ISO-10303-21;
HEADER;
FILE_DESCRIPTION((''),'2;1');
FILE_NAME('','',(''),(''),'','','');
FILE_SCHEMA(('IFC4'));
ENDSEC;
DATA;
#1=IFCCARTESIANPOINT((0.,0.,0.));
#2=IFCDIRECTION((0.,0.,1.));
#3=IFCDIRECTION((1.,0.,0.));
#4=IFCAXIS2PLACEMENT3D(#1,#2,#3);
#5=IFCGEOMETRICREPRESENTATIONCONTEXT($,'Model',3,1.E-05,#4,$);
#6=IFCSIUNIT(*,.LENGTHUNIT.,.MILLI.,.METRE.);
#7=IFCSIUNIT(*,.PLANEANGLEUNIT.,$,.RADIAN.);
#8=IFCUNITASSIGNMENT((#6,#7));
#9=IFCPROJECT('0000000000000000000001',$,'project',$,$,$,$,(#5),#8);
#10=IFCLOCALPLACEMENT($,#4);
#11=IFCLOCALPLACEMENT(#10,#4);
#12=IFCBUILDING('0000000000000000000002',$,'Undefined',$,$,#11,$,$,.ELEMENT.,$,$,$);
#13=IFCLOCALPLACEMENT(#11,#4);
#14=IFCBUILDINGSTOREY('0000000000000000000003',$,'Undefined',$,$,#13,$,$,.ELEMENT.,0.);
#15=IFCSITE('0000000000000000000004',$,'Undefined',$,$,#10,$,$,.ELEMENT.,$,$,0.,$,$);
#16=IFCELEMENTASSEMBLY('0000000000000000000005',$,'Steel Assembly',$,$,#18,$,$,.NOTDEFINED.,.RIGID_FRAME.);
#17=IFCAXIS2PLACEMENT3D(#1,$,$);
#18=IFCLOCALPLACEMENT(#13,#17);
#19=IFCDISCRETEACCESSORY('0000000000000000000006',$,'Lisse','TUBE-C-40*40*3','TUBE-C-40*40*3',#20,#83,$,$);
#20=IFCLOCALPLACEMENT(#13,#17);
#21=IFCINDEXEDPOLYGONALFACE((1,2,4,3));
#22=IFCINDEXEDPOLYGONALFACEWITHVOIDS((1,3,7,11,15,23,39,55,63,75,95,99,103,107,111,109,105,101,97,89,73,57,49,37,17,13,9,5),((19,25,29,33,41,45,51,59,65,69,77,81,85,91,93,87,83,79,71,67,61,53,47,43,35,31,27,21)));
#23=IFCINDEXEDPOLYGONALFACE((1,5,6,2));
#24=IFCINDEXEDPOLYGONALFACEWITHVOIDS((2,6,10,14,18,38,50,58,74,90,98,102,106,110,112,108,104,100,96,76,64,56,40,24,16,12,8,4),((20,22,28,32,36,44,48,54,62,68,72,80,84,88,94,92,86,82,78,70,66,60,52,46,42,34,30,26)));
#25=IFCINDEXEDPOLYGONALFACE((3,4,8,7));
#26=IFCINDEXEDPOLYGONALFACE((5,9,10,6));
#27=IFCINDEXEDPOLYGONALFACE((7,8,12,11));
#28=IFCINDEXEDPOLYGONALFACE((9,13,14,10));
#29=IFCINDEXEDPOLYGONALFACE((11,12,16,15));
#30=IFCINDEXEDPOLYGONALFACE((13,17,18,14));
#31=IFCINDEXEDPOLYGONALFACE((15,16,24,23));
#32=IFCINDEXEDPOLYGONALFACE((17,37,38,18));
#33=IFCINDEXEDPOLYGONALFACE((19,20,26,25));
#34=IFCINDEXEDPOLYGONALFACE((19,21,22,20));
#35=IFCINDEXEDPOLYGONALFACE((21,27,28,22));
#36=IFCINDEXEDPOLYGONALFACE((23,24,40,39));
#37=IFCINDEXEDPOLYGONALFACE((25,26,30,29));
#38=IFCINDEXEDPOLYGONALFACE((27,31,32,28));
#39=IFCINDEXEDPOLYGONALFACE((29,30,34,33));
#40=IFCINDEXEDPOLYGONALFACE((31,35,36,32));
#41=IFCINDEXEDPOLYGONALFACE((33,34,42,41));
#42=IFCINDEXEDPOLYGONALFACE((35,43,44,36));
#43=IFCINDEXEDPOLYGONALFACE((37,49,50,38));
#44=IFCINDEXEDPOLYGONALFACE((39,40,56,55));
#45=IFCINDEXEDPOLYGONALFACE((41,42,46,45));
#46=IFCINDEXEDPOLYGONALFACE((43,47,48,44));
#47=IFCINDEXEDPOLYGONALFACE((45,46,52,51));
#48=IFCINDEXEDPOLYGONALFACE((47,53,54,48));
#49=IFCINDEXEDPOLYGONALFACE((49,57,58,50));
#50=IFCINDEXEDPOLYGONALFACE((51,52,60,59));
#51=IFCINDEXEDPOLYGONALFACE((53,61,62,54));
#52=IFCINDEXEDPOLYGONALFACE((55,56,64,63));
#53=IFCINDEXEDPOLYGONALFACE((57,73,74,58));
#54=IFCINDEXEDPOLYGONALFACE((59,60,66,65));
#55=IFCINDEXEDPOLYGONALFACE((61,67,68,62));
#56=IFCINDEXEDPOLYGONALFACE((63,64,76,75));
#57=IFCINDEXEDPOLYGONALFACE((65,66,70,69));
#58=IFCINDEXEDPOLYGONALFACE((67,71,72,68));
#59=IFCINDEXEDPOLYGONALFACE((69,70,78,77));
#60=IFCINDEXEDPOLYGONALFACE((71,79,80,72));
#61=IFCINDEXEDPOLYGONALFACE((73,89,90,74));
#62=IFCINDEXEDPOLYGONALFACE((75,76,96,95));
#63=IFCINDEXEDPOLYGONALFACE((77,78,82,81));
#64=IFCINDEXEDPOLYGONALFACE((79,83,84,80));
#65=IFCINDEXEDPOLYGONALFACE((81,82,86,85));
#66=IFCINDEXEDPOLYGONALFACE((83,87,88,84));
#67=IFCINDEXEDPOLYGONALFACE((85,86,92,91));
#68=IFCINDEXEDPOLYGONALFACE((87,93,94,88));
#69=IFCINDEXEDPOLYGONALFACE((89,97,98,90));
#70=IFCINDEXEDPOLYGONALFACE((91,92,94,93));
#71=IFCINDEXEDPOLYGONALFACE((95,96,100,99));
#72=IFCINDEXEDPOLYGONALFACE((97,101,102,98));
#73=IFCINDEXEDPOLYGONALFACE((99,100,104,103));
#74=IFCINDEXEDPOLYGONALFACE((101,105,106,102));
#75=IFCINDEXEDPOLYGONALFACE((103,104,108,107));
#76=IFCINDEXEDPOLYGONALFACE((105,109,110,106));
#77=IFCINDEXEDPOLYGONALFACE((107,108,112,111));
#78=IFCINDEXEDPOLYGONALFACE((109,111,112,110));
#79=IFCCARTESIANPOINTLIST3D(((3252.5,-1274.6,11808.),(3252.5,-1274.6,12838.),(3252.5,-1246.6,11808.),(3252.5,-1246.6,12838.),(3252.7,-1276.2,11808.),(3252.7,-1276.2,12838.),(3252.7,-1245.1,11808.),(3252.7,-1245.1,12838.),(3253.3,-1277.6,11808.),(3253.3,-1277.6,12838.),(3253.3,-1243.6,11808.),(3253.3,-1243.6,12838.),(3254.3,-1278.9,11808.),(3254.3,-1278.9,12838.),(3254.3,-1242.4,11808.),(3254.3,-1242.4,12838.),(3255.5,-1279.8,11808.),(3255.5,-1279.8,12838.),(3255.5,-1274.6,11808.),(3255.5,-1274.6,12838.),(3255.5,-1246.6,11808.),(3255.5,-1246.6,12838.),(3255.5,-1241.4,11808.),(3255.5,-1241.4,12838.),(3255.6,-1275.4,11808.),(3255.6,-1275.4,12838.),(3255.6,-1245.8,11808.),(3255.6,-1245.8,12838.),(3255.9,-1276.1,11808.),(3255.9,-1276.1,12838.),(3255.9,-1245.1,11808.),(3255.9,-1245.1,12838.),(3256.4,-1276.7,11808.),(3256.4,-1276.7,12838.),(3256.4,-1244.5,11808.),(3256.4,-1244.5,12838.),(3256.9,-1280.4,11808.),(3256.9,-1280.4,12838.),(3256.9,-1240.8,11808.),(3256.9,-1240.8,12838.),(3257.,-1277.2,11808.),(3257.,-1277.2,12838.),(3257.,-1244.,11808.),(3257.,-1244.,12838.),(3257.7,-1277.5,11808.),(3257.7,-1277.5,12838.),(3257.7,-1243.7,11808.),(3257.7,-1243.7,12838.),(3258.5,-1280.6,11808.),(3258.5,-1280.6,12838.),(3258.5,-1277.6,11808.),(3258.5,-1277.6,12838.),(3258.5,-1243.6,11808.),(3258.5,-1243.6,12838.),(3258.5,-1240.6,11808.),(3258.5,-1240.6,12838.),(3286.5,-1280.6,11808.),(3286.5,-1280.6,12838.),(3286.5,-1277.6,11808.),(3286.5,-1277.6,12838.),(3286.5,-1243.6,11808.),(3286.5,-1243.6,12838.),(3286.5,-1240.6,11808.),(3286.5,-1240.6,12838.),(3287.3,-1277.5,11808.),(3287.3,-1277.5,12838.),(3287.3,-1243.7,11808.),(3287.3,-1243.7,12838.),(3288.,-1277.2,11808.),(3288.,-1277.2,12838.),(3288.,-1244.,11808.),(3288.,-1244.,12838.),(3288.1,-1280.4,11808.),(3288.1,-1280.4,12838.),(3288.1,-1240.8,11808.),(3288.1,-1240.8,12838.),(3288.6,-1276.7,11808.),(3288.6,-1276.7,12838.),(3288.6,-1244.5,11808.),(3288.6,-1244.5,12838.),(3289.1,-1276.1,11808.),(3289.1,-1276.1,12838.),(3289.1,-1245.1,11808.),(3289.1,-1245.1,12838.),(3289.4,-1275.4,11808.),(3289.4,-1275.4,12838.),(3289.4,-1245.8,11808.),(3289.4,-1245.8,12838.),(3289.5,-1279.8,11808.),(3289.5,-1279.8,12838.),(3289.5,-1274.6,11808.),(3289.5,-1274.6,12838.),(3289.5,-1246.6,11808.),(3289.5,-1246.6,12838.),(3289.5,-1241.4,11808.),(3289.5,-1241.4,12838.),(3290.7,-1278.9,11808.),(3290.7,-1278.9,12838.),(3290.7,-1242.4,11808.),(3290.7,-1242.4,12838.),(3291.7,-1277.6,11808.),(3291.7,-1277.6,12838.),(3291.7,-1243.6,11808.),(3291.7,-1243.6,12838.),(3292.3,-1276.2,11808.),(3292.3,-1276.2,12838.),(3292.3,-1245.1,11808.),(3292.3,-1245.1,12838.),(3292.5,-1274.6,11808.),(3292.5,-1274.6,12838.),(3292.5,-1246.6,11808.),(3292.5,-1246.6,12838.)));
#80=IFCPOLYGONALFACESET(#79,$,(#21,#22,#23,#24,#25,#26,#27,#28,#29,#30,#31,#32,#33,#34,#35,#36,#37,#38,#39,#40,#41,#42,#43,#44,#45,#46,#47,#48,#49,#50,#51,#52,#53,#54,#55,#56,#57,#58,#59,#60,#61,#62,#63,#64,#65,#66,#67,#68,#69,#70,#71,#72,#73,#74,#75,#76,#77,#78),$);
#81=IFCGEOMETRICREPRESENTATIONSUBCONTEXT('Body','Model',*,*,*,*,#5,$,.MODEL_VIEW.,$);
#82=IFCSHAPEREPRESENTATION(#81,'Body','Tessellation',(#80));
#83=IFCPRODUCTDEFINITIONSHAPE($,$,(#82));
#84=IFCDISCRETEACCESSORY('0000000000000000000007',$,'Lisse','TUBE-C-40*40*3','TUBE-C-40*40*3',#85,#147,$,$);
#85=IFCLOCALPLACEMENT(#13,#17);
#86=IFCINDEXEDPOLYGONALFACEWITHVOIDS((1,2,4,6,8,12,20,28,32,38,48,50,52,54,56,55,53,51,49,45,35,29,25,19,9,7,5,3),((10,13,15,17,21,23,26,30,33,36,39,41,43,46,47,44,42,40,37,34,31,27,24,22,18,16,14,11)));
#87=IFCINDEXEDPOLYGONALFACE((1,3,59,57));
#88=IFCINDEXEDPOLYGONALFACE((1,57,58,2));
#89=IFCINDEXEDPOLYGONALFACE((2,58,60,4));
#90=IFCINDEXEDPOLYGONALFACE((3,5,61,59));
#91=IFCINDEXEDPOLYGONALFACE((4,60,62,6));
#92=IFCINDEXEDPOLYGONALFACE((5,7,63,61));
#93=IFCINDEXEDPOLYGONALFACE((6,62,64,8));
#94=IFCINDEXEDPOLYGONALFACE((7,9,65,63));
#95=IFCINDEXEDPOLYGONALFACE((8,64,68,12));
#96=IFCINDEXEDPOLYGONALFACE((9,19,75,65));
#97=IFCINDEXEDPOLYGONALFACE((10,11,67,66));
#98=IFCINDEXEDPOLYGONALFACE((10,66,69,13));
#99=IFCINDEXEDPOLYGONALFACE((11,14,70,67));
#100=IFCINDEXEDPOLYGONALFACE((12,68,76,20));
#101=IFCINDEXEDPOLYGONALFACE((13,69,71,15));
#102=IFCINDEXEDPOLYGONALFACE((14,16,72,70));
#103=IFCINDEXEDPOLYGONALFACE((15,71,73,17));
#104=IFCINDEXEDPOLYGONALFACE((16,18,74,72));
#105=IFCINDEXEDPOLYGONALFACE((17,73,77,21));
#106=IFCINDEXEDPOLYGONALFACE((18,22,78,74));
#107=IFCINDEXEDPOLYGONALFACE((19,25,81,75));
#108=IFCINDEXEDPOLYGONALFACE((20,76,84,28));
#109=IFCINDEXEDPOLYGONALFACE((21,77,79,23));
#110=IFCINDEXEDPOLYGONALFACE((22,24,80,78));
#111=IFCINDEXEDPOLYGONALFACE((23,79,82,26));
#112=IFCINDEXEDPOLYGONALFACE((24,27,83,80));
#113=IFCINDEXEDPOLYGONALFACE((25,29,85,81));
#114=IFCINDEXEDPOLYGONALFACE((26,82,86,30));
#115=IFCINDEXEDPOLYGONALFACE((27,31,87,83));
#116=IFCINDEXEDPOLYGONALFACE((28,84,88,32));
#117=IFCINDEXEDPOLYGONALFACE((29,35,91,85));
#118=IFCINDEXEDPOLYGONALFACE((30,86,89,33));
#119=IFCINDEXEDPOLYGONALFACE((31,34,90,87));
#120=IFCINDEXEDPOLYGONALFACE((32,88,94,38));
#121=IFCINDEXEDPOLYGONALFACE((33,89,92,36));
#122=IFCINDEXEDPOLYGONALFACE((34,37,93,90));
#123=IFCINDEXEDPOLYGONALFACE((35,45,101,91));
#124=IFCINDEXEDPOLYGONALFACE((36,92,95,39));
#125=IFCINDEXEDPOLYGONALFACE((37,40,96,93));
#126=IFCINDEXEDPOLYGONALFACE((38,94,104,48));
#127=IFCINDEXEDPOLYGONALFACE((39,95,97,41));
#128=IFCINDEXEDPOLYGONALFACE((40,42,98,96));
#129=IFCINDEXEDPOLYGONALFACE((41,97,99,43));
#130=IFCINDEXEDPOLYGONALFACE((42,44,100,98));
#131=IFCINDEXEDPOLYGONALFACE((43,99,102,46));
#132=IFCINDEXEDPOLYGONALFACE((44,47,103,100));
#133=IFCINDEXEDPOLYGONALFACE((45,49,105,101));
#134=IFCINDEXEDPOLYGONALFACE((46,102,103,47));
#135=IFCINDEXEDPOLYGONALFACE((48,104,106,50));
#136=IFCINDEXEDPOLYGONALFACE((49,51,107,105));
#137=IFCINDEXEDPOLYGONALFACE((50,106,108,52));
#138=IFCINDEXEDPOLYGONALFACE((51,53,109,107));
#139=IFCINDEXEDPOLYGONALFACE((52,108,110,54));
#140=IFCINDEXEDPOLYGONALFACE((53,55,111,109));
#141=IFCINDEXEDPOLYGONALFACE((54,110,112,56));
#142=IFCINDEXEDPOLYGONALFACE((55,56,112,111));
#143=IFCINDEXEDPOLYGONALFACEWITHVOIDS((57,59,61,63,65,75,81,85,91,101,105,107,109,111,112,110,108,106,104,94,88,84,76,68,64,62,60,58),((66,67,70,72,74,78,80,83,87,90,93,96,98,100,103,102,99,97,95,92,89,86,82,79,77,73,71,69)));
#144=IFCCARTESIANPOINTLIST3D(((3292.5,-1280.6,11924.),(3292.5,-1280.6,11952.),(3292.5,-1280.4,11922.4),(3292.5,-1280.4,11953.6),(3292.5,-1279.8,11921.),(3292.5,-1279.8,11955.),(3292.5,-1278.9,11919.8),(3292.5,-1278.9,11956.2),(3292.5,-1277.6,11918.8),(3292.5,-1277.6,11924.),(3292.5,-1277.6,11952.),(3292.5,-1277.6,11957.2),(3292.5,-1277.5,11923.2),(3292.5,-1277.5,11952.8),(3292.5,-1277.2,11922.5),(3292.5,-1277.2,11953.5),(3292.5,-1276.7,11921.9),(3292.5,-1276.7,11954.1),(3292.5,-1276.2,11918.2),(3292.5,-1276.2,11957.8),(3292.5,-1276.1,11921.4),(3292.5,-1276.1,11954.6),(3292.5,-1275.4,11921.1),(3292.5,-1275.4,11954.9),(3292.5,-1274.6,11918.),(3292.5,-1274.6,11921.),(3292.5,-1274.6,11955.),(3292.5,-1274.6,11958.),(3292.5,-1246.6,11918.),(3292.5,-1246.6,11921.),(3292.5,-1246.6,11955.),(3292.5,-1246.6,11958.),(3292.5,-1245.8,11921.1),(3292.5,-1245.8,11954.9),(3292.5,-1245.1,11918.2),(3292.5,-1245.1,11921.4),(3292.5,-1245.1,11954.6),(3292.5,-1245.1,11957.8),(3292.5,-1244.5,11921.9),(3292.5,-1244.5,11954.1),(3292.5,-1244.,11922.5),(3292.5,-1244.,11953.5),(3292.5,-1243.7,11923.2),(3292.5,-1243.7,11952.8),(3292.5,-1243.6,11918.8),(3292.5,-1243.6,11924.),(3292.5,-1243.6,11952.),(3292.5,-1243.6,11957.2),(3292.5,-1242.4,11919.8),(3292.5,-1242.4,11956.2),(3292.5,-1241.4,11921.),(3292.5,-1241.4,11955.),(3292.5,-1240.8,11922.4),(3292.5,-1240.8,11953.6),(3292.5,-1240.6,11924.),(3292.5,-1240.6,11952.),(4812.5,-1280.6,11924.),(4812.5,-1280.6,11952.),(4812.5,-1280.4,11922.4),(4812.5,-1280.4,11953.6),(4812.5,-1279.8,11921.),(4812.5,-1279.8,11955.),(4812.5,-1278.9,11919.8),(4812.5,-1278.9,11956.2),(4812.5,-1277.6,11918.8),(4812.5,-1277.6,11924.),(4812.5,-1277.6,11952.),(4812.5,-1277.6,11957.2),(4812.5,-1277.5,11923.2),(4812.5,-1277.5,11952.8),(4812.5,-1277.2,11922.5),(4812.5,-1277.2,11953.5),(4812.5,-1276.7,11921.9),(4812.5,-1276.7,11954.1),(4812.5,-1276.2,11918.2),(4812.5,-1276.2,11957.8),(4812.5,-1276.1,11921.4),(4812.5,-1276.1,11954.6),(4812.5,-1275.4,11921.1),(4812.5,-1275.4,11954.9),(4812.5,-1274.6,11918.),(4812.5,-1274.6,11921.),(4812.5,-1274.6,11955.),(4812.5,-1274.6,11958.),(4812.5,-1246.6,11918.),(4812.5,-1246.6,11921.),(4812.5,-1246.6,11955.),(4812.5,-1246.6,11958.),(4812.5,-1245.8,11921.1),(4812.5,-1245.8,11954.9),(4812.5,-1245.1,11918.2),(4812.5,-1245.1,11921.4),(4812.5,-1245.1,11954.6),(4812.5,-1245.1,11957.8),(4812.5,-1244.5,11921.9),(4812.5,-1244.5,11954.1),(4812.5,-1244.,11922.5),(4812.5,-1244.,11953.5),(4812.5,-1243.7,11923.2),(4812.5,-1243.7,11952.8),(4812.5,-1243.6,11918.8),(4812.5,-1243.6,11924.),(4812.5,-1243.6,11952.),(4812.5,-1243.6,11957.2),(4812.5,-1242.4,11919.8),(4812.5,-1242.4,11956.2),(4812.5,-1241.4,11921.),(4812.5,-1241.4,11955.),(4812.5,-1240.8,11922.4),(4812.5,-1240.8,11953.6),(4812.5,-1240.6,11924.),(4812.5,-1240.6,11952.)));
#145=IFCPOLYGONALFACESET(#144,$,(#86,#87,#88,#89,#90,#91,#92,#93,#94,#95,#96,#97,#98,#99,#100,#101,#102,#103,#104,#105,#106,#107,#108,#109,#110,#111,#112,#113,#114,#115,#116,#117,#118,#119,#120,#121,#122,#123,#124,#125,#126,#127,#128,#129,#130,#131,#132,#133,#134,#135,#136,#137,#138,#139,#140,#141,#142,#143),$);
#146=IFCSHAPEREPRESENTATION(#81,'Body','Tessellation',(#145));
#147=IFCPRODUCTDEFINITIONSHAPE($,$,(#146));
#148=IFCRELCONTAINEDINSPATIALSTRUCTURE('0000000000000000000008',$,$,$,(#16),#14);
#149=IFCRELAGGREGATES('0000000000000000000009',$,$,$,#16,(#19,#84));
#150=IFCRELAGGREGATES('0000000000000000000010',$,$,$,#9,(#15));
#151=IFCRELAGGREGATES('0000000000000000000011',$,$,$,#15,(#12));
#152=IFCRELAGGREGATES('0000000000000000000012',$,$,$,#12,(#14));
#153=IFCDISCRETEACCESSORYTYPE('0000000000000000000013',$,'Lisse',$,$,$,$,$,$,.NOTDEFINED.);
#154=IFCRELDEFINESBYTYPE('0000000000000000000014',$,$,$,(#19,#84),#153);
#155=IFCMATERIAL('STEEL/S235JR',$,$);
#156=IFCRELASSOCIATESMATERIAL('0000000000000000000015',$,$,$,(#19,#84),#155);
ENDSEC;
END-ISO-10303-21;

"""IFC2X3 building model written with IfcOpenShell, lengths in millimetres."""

from ifc_helpers import new_model, si_unit, frame, origin_with_axes, origin_2d_with_axis, place, context, subcontext, project, spatial, hollow_rectangle, extrude, material, type_object, element, aggregate, save


model = new_model("IFC2X3")

# Units and contexts
model_context = context("Model", 3, precision=1e-05, world=origin_with_axes())
body_context = subcontext(model_context, "Body", "Model", "MODEL_VIEW")
ifc_project = project(units=[si_unit("LENGTHUNIT", "METRE", prefix="MILLI"), si_unit("PLANEANGLEUNIT", "RADIAN")], contexts=[model_context])

# Site, building, storey
site_placement = place(None, origin_with_axes())
site = spatial("IfcSite", under=ifc_project, at=site_placement, Name="Undefined", CompositionType="ELEMENT", RefElevation=0.0)
building_placement = place(site_placement, origin_with_axes())
building = spatial("IfcBuilding", under=site, at=building_placement, Name="Undefined", CompositionType="ELEMENT")
storey_placement = place(building_placement, origin_with_axes())
storey = spatial("IfcBuildingStorey", under=building, at=storey_placement, Name="Undefined", CompositionType="ELEMENT", Elevation=0.0)

# Shared definitions
ifc_material_1 = material(Name="STEEL/S235JR")

# Element assembly
assembly_1_placement = place(storey_placement, origin_with_axes())
assembly_1 = element("IfcElementAssembly", 1, at=assembly_1_placement, inside=storey, Name="Steel Assembly", AssemblyPlace="NOTDEFINED", PredefinedType="RIGID_FRAME")

# Discrete accessories
discrete_accessory_type_1 = type_object("IfcDiscreteAccessoryType", Name="Lisse")
discrete_accessory_1_placement = place(assembly_1_placement, frame((3272.5, -1260.6, 12838.0), z_axis=(0.0, 1.0, 0.0), x_axis=(0.0, 0.0, -1.0)))
discrete_accessory_1 = element("IfcDiscreteAccessory", 2, at=discrete_accessory_1_placement, type_object=discrete_accessory_type_1, material=ifc_material_1, Name="Lisse", Description="TUBE-C-40*40*3", ObjectType="TUBE-C-40*40*3", context=body_context, shape_type="SweptSolid", body=[
    extrude(hollow_rectangle(XDim=40.0, YDim=40.0, WallThickness=3.0, InnerFilletRadius=3.0, OuterFilletRadius=6.0, at=origin_2d_with_axis()), frame((1030.0, 0.0, 0.0), z_axis=(-1.0, 0.0, 0.0), x_axis=(0.0, -1.0, 0.0)), (0.0, 0.0, 1.0), 1030.0),
])
discrete_accessory_2_placement = place(assembly_1_placement, frame((4812.5, -1260.6, 11938.0), z_axis=(0.0, 1.0, 0.0), x_axis=(-1.0, 0.0, 0.0)))
discrete_accessory_2 = element("IfcDiscreteAccessory", 3, at=discrete_accessory_2_placement, type_object=discrete_accessory_type_1, material=ifc_material_1, Name="Lisse", Description="TUBE-C-40*40*3", ObjectType="TUBE-C-40*40*3", context=body_context, shape_type="SweptSolid", body=[
    extrude(hollow_rectangle(XDim=40.0, YDim=40.0, WallThickness=3.0, InnerFilletRadius=3.0, OuterFilletRadius=6.0, at=origin_2d_with_axis()), frame((1520.0, 0.0, 0.0), z_axis=(-1.0, 0.0, 0.0), x_axis=(0.0, -1.0, 0.0)), (0.0, 0.0, 1.0), 1520.0),
])
aggregate(assembly_1, [discrete_accessory_1, discrete_accessory_2])

save(model, "model.ifc")
